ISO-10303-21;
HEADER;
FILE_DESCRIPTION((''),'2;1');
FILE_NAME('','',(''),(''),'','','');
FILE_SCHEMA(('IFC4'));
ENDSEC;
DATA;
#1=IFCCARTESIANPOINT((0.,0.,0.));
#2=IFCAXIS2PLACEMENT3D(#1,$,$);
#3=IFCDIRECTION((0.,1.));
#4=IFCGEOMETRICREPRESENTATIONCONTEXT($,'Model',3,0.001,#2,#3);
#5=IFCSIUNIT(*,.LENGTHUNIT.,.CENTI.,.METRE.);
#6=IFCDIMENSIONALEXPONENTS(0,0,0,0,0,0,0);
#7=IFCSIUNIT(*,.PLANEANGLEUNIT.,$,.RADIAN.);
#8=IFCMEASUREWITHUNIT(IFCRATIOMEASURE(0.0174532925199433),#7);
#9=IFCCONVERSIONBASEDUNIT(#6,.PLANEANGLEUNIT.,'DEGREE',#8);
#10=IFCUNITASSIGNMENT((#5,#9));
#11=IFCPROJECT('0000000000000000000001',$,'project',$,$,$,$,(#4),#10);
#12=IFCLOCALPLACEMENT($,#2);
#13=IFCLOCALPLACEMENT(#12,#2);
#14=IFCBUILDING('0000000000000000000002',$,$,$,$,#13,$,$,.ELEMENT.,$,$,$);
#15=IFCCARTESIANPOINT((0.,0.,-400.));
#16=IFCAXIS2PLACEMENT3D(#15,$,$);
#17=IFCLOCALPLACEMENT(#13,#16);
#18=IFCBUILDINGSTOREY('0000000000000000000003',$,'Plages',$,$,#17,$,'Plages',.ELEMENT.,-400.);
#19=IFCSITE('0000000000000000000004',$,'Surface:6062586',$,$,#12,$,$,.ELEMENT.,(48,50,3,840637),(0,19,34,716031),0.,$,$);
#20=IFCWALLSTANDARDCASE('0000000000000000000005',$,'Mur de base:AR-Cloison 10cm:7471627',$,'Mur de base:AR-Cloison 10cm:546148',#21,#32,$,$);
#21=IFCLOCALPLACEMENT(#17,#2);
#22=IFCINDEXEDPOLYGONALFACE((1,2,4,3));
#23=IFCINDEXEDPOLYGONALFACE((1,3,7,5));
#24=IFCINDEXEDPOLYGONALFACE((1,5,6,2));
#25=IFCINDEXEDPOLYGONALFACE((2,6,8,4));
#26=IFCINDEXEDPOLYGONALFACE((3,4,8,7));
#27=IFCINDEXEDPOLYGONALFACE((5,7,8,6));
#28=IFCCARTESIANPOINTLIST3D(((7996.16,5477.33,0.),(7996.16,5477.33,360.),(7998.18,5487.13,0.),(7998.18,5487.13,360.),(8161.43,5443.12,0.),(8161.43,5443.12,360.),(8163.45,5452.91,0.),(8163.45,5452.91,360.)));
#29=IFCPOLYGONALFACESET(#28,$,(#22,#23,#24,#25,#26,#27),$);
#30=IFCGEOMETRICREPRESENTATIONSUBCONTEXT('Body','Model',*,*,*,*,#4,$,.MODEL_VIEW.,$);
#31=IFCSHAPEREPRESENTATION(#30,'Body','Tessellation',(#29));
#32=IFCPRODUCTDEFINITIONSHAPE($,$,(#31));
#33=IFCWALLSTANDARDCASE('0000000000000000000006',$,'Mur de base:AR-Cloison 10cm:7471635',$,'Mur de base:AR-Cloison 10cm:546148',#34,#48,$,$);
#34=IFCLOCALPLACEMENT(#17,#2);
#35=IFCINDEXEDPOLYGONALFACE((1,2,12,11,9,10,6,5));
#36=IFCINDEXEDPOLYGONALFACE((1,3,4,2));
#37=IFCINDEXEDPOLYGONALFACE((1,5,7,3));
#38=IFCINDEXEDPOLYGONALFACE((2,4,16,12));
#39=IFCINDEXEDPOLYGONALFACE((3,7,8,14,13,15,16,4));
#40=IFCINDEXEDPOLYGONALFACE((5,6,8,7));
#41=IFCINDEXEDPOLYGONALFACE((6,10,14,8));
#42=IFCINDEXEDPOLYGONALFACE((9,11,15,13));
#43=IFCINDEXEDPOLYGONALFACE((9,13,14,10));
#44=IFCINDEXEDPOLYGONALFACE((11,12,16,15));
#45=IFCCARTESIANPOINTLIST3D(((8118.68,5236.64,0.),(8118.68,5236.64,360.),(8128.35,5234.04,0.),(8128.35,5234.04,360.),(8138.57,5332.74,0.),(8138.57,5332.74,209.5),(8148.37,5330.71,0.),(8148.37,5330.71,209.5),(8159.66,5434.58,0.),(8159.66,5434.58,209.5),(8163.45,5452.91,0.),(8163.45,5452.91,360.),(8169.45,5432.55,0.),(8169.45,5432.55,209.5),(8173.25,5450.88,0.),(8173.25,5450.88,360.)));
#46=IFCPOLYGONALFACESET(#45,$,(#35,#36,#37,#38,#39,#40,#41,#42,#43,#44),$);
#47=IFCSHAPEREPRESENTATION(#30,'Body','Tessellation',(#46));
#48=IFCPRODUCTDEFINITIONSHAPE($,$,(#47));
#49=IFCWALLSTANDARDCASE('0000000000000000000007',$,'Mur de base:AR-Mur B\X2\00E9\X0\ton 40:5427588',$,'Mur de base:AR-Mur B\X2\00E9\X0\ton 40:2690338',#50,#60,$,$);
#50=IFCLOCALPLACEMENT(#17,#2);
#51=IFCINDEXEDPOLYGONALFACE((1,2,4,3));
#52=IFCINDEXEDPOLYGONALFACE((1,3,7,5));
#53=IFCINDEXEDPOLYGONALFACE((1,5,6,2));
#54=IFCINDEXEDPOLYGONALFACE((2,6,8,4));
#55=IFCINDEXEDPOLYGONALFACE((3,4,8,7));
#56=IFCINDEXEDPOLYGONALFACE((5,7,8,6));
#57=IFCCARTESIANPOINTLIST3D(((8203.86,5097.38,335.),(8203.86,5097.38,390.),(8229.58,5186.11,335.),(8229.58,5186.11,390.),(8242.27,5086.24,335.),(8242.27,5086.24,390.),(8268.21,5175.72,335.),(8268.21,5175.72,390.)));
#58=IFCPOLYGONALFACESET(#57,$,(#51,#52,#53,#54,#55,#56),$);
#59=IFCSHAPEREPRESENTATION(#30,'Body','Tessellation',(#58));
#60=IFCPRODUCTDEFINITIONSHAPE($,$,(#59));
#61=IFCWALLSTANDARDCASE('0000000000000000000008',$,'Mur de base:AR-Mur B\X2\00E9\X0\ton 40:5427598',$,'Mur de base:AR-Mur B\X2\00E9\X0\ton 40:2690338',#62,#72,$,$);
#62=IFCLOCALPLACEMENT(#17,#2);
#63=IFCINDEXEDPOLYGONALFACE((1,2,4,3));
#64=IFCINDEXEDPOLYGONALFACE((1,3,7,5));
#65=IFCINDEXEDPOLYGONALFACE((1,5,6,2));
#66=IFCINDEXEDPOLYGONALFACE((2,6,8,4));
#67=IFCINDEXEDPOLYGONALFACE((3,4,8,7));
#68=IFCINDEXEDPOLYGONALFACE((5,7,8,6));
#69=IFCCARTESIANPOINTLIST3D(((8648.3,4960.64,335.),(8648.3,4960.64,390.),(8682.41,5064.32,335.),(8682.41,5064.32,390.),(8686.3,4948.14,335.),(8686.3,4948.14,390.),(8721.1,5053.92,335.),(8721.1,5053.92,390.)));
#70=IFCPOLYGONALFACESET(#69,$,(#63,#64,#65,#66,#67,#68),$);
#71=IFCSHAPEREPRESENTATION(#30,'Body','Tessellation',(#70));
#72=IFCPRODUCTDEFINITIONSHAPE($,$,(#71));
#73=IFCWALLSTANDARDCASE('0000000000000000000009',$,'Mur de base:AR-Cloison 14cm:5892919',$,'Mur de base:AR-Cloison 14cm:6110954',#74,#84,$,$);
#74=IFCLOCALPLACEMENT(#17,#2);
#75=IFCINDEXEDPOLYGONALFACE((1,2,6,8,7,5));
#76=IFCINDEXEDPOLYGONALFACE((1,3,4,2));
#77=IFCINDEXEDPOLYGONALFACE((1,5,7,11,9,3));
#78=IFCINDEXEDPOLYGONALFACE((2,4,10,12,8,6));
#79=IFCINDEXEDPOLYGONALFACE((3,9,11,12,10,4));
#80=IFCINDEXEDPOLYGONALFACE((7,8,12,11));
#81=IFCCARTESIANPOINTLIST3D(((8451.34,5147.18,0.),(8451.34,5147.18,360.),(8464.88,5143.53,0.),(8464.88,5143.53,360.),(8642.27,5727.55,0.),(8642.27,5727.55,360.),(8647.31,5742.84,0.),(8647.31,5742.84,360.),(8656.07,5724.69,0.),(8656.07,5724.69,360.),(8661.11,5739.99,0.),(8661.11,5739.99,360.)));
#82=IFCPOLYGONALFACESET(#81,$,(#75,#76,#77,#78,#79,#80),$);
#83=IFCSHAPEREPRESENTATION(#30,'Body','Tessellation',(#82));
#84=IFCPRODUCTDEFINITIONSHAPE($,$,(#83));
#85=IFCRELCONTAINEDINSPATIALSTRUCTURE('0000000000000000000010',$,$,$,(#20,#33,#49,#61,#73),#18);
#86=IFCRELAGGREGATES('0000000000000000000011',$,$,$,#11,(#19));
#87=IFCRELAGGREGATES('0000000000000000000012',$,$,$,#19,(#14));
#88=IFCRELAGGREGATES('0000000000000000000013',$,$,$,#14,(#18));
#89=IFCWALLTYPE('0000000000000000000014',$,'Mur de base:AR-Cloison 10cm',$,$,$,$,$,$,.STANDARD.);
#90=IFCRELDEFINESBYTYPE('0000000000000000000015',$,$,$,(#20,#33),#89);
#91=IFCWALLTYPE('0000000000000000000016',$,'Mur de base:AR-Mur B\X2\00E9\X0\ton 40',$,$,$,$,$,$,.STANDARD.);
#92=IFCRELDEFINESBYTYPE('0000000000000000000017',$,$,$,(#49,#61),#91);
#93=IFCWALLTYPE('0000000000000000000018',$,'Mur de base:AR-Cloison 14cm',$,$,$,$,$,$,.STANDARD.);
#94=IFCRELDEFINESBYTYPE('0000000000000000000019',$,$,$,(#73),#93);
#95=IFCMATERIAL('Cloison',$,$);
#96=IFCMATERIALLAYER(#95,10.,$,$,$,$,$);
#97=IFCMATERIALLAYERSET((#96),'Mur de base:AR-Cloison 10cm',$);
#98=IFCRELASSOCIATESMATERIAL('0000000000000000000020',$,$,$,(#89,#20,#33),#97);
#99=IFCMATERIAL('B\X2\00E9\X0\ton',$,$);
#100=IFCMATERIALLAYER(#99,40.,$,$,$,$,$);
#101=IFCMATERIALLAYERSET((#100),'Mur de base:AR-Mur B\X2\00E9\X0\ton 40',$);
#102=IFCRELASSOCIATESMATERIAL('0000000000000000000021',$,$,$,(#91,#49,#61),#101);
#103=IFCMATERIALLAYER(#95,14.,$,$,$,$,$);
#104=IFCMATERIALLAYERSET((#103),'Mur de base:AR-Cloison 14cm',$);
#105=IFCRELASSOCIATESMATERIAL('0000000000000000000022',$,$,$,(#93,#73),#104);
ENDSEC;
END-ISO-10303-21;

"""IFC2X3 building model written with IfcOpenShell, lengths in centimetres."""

from ifc_helpers import new_model, entity, si_unit, converted_unit, direction, frame, frame_2d, origin, place, context, subcontext, project, spatial, polyline, rectangle, outline, extrude, material, layer, layer_set, layer_usage, type_object, element, save


model = new_model("IFC2X3")

# Units and contexts
model_context = context("Model", 3, precision=0.001, world=origin(), true_north=direction((0.0, 1.0)))
body_context = subcontext(model_context, "Body", "Model", "MODEL_VIEW")
ifc_project = project(units=[si_unit("LENGTHUNIT", "METRE", prefix="CENTI"), converted_unit("PLANEANGLEUNIT", "DEGREE", entity("IfcRatioMeasure", 0.0174532925199433), si_unit("PLANEANGLEUNIT", "RADIAN"), dimensions=[0, 0, 0, 0, 0, 0, 0])], contexts=[model_context])

# Site, building, storey
site_placement = place(None, origin())
site = spatial("IfcSite", under=ifc_project, at=site_placement, Name="Surface:6062586", CompositionType="ELEMENT", RefLatitude=(48, 50, 3, 840637), RefLongitude=(0, 19, 34, 716031), RefElevation=0.0)
building_placement = place(site_placement, origin())
building = spatial("IfcBuilding", under=site, at=building_placement, CompositionType="ELEMENT")
storey_placement = place(building_placement, frame((0.0, 0.0, -400.0)))
storey = spatial("IfcBuildingStorey", under=building, at=storey_placement, Name="Plages", LongName="Plages", CompositionType="ELEMENT", Elevation=-400.0)

# Shared definitions
ifc_material_1 = material(Name="Béton")

# Wall
ifc_material_2 = material(Name="Cloison")
ifc_layer_1 = layer(ifc_material_2, 10.0)
ifc_layer_set_1 = layer_set([ifc_layer_1], Name="Mur de base:AR-Cloison 10cm")
ifc_layer_usage_1 = layer_usage(ifc_layer_set_1, "AXIS2", "NEGATIVE", 5.0)
wall_type_1 = type_object("IfcWallType", Name="Mur de base:AR-Cloison 10cm", PredefinedType="STANDARD", material=ifc_layer_set_1)
wall_1_placement = place(storey_placement, frame((8162.44, 5448.01, 0.0), z_axis=(0.0, 0.0, 1.0), x_axis=(-0.979231, 0.202745, 0.0)))
element("IfcWallStandardCase", 1, at=wall_1_placement, inside=storey, type_object=wall_type_1, material=ifc_layer_usage_1, Name="Mur de base:AR-Cloison 10cm:7471627", ObjectType="Mur de base:AR-Cloison 10cm:546148", context=body_context, shape_type="SweptSolid", body=[
    extrude(rectangle(XDim=168.78, YDim=10.0, at=frame_2d((84.39, 0.0), x_axis=(-1.0, 0.0))), origin(), (0.0, 0.0, 1.0), 360.0),
])

# Wall, opening
ifc_layer_usage_2 = layer_usage(ifc_layer_set_1, "AXIS2", "NEGATIVE", 5.0)
wall_2_placement = place(storey_placement, frame((8168.35, 5451.89, 0.0), z_axis=(0.0, 0.0, 1.0), x_axis=(-0.202745, -0.979231, 0.0)))
wall_2 = element("IfcWallStandardCase", 2, at=wall_2_placement, inside=storey, type_object=wall_type_1, material=ifc_layer_usage_2, Name="Mur de base:AR-Cloison 10cm:7471635", ObjectType="Mur de base:AR-Cloison 10cm:546148", context=body_context, shape_type="SweptSolid", body=[
    extrude(outline(polyline([(0.0, -5.0), (10.0, -5.0), (220.85, -5.0), (221.44, 5.0), (0.0, 5.0), (0.0, -5.0)])), origin(), (0.0, 0.0, 1.0), 360.0),
])
opening_1_placement = place(wall_2_placement, frame((18.72, -5.0, 0.0)))
element("IfcOpeningElement", 3, at=opening_1_placement, cuts=wall_2, ObjectType="Opening", context=body_context, shape_type="SweptSolid", body=[
    extrude(rectangle(XDim=209.5, YDim=104.0, at=frame_2d((104.75, 52.0), x_axis=(1.0, 0.0))), frame((0.0, 0.0, 0.0), z_axis=(0.0, 1.0, 0.0), x_axis=(0.0, 0.0, 1.0)), (0.0, 0.0, 1.0), 10.0),
])

# Shared definitions
ifc_layer_2 = layer(ifc_material_1, 40.0)
ifc_layer_set_2 = layer_set([ifc_layer_2], Name="Mur de base:AR-Mur Béton 40")
wall_type_2 = type_object("IfcWallType", Name="Mur de base:AR-Mur Béton 40", PredefinedType="STANDARD", material=ifc_layer_set_2)

# Walls
ifc_layer_usage_3 = layer_usage(ifc_layer_set_2, "AXIS2", "NEGATIVE", 20.0)
wall_3_placement = place(storey_placement, frame((8223.06, 5091.81, 335.0), z_axis=(0.0, 0.0, 1.0), x_axis=(0.278465, 0.960446, 0.0)))
element("IfcWallStandardCase", 4, at=wall_3_placement, inside=storey, type_object=wall_type_2, material=ifc_layer_usage_3, Name="Mur de base:AR-Mur Béton 40:5427588", ObjectType="Mur de base:AR-Mur Béton 40:2690338", context=body_context, shape_type="SweptSolid", body=[
    extrude(outline(polyline([(93.16, -20.0), (92.38, 20.0), (0.0, 20.0), (0.0, -20.0), (93.16, -20.0)])), origin(), (0.0, 0.0, 1.0), 55.0),
])
ifc_layer_usage_4 = layer_usage(ifc_layer_set_2, "AXIS2", "NEGATIVE", 20.0)
wall_4_placement = place(storey_placement, frame((8667.3, 4954.39, 335.0), z_axis=(0.0, 0.0, 1.0), x_axis=(0.312506, 0.949916, 0.0)))
element("IfcWallStandardCase", 5, at=wall_4_placement, inside=storey, type_object=wall_type_2, material=ifc_layer_usage_4, Name="Mur de base:AR-Mur Béton 40:5427598", ObjectType="Mur de base:AR-Mur Béton 40:2690338", context=body_context, shape_type="SweptSolid", body=[
    extrude(outline(polyline([(111.36, -20.0), (109.15, 20.0), (0.0, 20.0), (0.0, -20.0), (111.36, -20.0)])), origin(), (0.0, 0.0, 1.0), 55.0),
])

# Wall
ifc_layer_3 = layer(ifc_material_2, 14.0)
ifc_layer_set_3 = layer_set([ifc_layer_3], Name="Mur de base:AR-Cloison 14cm")
ifc_layer_usage_5 = layer_usage(ifc_layer_set_3, "AXIS2", "NEGATIVE", 7.0)
wall_type_3 = type_object("IfcWallType", Name="Mur de base:AR-Cloison 14cm", PredefinedType="STANDARD", material=ifc_layer_set_3)
wall_5_placement = place(storey_placement, frame((8457.99, 5144.99, 0.0), z_axis=(0.0, 0.0, 1.0), x_axis=(0.312506, 0.949916, 0.0)))
element("IfcWallStandardCase", 6, at=wall_5_placement, inside=storey, type_object=wall_type_3, material=ifc_layer_usage_5, Name="Mur de base:AR-Cloison 14cm:5892919", ObjectType="Mur de base:AR-Cloison 14cm:6110954", context=body_context, shape_type="SweptSolid", body=[
    extrude(outline(polyline([(628.67, -7.0), (627.07, 7.0), (610.97, 7.0), (0.0, 7.0), (0.77, -7.0), (612.57, -7.0), (628.67, -7.0)])), origin(), (0.0, 0.0, 1.0), 360.0),
])

save(model, "model.ifc")
